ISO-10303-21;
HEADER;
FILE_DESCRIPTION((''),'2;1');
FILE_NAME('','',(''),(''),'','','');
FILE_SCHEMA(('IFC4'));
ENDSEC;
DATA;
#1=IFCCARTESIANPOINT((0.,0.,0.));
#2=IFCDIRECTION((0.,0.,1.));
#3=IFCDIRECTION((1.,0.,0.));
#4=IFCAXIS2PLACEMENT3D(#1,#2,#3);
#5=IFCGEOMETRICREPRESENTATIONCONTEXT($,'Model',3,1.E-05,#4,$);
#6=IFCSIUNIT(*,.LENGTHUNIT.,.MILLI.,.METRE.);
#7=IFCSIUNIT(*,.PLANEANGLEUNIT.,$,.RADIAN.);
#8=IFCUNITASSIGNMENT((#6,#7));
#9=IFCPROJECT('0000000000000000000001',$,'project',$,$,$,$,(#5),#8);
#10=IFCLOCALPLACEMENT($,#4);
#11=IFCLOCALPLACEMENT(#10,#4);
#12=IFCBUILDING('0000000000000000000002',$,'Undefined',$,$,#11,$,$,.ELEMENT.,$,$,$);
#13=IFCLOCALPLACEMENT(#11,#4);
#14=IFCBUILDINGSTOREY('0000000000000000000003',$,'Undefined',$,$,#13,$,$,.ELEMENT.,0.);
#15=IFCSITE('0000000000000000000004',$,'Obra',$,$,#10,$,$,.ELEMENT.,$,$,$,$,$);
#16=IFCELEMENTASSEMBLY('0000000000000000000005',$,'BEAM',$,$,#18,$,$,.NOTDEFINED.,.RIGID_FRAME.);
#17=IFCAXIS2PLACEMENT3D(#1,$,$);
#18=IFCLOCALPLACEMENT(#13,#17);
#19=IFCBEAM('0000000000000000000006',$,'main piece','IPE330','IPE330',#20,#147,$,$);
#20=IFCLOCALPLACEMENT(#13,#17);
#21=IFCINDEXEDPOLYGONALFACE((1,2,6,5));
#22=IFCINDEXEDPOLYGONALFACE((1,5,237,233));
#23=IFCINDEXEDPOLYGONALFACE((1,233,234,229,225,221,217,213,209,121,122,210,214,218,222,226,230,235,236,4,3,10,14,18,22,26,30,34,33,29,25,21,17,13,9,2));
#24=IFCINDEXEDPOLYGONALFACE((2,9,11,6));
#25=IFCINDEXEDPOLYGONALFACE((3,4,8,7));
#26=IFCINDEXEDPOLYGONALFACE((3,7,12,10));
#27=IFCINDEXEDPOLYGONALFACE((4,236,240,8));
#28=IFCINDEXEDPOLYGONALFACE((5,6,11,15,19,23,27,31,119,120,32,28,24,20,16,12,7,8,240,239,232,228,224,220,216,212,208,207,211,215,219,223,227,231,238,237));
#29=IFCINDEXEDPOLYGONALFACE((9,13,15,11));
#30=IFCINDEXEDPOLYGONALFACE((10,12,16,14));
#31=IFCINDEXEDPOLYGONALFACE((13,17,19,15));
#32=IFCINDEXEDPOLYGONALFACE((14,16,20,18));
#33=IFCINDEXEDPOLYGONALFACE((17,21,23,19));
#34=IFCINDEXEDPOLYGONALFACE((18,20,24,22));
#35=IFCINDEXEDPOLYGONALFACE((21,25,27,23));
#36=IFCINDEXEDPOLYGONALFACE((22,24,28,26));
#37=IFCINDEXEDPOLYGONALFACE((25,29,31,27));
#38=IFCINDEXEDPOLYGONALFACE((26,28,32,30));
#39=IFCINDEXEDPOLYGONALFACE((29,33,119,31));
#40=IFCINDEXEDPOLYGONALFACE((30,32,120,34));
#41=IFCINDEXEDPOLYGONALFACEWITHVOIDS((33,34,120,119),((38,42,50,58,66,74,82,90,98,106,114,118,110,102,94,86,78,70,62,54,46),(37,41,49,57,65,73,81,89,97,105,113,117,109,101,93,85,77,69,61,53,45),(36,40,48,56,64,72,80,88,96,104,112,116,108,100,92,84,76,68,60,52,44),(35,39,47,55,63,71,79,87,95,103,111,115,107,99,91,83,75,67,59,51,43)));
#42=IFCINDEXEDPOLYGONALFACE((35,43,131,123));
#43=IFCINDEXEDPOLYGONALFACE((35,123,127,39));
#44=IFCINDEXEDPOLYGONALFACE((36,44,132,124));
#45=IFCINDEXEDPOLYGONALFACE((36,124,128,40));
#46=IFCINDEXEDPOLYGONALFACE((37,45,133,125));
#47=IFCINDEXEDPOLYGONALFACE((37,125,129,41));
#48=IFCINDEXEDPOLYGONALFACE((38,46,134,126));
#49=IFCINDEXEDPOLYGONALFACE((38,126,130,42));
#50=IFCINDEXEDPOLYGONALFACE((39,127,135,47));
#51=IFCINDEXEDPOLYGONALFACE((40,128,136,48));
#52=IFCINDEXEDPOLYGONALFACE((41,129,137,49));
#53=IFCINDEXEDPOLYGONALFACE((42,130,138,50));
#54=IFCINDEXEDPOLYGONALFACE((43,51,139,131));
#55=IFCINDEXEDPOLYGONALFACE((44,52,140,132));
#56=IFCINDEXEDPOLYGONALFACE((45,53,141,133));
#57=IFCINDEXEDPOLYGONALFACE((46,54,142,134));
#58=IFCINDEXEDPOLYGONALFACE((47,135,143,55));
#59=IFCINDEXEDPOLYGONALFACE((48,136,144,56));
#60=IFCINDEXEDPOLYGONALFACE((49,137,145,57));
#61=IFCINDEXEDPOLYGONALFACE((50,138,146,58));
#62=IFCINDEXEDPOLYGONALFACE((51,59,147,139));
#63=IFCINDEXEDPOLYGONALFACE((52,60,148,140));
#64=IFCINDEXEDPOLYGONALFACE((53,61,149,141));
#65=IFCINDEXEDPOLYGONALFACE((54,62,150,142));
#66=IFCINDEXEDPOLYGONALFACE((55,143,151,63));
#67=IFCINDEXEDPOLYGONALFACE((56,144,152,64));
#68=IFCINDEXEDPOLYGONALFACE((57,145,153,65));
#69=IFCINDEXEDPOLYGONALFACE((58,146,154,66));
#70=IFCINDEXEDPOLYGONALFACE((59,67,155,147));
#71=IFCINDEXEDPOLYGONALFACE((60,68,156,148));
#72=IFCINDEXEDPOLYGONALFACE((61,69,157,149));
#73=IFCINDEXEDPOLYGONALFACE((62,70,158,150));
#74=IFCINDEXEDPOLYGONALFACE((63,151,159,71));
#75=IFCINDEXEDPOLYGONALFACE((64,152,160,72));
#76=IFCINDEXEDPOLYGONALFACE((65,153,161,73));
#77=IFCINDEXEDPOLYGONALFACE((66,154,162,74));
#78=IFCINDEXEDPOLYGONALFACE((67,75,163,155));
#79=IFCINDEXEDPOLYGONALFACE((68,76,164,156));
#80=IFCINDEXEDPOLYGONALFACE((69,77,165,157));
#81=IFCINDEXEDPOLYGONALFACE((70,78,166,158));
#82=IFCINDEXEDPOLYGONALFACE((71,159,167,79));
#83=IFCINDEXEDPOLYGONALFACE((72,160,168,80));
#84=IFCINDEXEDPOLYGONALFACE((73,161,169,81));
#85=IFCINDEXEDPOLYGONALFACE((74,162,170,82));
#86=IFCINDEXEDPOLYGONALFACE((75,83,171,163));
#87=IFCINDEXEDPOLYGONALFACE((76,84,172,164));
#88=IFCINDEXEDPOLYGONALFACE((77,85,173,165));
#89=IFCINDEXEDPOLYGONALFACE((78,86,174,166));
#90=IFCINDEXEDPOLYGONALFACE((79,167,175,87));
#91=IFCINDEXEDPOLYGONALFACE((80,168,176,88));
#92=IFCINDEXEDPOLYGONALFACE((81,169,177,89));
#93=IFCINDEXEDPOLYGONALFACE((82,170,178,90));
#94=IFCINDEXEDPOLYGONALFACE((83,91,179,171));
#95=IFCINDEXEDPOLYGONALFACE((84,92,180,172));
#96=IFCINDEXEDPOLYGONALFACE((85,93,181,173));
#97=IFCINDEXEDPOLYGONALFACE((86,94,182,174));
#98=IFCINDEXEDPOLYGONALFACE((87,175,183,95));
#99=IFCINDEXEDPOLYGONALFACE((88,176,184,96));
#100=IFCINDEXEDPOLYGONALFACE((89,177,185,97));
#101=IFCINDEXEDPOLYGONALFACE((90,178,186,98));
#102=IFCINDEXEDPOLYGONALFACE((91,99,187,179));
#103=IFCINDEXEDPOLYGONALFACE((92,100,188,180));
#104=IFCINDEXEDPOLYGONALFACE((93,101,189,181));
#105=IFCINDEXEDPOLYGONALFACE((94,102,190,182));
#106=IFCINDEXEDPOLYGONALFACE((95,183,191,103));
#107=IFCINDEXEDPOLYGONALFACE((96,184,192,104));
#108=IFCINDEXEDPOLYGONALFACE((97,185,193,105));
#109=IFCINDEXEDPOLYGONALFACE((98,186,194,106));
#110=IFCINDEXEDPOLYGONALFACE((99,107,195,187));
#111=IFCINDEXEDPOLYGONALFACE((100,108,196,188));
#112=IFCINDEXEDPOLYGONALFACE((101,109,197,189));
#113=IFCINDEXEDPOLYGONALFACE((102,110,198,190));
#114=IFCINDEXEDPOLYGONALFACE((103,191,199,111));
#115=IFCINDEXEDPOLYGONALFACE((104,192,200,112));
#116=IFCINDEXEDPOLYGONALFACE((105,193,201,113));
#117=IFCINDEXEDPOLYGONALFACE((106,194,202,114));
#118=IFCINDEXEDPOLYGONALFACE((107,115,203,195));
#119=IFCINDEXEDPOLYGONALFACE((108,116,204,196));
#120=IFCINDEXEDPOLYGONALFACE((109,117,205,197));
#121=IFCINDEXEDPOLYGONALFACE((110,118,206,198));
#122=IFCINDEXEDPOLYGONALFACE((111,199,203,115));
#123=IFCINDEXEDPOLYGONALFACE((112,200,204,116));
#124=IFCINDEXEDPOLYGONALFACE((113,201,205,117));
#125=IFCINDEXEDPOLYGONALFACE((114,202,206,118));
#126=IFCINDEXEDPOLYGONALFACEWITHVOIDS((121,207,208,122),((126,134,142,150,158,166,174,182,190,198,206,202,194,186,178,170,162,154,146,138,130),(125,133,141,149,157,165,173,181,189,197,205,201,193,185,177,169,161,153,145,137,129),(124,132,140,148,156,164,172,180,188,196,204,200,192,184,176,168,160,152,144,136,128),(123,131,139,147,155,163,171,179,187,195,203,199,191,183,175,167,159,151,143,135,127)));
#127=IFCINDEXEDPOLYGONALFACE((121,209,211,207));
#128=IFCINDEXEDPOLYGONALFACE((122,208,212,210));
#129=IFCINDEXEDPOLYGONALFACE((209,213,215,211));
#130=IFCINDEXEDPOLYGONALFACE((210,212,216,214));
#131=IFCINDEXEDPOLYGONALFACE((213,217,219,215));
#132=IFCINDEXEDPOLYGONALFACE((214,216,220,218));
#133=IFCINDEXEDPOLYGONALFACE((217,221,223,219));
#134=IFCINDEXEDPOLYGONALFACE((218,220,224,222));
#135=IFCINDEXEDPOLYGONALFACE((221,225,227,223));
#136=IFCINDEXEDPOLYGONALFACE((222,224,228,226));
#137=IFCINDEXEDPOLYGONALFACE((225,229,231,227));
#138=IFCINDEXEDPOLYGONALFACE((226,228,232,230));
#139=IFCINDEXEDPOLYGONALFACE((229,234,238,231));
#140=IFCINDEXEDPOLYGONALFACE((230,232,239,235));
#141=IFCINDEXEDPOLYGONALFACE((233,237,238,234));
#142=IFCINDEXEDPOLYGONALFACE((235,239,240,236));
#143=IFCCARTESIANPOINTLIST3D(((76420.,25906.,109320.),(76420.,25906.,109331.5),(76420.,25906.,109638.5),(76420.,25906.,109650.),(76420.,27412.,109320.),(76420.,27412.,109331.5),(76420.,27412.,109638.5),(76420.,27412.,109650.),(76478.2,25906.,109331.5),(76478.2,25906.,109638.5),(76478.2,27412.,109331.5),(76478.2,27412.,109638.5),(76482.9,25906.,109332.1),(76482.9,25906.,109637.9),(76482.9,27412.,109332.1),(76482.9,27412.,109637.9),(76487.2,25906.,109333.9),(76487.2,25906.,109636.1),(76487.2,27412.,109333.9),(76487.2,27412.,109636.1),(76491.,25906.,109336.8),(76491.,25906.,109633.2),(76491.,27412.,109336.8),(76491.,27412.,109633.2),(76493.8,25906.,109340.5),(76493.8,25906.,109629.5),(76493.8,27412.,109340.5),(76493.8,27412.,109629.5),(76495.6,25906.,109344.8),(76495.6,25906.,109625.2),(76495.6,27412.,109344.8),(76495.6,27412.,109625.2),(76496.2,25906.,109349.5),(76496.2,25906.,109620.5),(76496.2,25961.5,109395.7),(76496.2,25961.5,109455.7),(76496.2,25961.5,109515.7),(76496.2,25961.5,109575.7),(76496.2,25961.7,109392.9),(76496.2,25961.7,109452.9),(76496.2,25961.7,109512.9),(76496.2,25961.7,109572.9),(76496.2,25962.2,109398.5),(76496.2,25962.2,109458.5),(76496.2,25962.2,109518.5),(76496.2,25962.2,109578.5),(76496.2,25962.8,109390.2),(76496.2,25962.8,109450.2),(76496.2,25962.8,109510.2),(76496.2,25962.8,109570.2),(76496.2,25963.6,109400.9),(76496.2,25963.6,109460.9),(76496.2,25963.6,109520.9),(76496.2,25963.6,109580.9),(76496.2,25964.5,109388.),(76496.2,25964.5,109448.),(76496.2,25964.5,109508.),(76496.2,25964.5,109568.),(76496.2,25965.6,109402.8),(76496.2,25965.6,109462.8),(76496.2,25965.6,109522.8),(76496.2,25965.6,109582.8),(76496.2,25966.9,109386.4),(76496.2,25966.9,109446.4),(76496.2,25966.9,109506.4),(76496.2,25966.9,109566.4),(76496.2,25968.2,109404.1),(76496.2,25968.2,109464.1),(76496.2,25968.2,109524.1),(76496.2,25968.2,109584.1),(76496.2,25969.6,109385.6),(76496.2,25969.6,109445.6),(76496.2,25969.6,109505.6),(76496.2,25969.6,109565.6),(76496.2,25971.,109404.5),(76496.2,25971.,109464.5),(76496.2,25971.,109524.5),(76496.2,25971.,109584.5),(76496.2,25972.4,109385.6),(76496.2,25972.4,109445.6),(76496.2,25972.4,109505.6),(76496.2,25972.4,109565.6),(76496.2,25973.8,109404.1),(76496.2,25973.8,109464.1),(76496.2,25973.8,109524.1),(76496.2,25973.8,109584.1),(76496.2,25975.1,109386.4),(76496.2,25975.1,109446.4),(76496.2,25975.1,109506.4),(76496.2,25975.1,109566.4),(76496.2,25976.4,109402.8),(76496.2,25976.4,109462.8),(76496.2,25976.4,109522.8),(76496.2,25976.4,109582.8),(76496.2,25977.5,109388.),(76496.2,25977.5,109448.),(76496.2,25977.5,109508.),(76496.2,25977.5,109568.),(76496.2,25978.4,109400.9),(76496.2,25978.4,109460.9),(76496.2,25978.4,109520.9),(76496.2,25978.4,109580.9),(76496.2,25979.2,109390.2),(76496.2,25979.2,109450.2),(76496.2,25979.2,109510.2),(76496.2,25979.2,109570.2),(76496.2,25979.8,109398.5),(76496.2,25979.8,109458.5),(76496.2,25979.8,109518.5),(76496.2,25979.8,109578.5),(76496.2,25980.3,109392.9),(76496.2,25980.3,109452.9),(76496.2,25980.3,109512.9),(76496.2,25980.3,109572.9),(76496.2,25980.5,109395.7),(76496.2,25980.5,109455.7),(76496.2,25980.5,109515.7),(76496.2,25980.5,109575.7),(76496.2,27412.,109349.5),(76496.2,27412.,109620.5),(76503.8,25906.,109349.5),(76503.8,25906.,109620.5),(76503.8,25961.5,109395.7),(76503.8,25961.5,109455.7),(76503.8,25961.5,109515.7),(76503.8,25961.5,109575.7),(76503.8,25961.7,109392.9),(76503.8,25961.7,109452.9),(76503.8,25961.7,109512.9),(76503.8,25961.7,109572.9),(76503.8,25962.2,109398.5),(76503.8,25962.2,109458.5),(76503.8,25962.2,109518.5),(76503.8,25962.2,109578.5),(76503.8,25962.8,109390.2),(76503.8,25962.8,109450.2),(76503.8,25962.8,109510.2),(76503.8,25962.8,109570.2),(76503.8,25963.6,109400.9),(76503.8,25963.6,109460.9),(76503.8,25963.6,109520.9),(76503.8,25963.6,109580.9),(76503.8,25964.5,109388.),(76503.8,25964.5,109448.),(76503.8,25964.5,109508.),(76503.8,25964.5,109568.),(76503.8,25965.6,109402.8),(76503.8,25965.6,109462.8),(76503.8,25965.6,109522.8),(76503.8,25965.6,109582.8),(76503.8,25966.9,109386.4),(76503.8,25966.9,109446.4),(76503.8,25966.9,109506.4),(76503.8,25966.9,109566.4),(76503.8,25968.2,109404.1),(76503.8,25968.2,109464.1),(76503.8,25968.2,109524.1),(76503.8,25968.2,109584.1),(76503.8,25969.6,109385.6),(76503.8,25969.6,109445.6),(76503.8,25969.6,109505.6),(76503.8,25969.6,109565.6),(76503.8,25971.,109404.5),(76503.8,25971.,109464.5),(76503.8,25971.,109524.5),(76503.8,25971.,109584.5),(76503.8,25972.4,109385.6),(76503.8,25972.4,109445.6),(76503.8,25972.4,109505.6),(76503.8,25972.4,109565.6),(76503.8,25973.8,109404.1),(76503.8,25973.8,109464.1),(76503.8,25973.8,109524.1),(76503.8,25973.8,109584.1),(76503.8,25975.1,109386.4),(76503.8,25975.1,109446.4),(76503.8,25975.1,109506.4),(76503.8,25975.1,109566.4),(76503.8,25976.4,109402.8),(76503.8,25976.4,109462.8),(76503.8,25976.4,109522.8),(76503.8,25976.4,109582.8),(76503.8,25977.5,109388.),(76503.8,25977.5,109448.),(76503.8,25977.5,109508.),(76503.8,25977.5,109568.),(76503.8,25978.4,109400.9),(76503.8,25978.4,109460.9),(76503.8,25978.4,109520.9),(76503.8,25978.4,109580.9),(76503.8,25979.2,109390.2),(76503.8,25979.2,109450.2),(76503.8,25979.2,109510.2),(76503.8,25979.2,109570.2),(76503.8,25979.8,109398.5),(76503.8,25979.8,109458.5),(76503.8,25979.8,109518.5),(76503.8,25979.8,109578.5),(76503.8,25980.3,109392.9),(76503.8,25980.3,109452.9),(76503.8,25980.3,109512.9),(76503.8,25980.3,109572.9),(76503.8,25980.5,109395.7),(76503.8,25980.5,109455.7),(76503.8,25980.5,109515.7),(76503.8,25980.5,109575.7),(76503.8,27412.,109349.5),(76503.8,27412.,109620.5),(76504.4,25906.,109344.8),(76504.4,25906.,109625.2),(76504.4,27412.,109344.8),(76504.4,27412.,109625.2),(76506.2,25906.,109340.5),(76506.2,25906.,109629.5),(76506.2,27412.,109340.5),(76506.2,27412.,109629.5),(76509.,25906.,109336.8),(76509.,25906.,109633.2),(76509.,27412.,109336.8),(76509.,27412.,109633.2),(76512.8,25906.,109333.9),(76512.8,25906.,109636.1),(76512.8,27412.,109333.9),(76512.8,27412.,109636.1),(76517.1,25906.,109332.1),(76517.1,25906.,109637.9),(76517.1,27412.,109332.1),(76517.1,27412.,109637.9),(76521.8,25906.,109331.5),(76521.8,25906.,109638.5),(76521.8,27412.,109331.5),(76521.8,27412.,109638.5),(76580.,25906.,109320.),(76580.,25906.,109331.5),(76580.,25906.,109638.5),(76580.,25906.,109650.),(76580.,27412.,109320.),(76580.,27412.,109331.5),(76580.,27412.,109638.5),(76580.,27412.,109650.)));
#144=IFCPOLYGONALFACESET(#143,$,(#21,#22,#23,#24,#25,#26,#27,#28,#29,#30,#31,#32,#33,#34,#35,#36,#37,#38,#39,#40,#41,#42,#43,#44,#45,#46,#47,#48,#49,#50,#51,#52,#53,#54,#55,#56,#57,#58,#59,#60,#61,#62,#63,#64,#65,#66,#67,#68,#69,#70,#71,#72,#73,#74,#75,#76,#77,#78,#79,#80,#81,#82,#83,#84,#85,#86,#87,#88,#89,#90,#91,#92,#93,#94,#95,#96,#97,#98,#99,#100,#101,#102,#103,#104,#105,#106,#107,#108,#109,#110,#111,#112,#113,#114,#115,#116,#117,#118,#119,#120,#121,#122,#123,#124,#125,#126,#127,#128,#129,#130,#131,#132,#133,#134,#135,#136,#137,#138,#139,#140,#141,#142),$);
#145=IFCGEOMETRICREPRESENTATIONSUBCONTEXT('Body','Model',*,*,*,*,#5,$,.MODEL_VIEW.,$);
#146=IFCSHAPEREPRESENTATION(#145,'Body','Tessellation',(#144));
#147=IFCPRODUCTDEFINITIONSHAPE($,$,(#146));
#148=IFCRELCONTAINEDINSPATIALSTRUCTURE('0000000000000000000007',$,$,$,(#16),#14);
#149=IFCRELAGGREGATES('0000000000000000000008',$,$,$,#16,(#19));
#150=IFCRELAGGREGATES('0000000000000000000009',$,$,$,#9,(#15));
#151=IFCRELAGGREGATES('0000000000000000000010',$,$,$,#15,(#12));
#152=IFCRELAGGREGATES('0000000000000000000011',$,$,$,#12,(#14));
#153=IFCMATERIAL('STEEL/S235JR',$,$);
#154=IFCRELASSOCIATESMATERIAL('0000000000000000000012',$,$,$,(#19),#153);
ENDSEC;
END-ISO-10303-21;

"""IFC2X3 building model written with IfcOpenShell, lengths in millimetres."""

from ifc_helpers import new_model, si_unit, frame, origin_with_axes, origin_2d_with_axis, place, context, subcontext, project, spatial, circle, i_section, extrude, clip, halfspace, source, transform, mapped, material, element, aggregate, save


model = new_model("IFC2X3")

# Units and contexts
model_context = context("Model", 3, precision=1e-05, world=origin_with_axes())
body_context = subcontext(model_context, "Body", "Model", "MODEL_VIEW")
ifc_project = project(units=[si_unit("LENGTHUNIT", "METRE", prefix="MILLI"), si_unit("PLANEANGLEUNIT", "RADIAN")], contexts=[model_context])

# Site, building, storey
site_placement = place(None, origin_with_axes())
site = spatial("IfcSite", under=ifc_project, at=site_placement, Name="Obra", CompositionType="ELEMENT")
building_placement = place(site_placement, origin_with_axes())
building = spatial("IfcBuilding", under=site, at=building_placement, Name="Undefined", CompositionType="ELEMENT")
storey_placement = place(building_placement, origin_with_axes())
storey = spatial("IfcBuildingStorey", under=building, at=storey_placement, Name="Undefined", CompositionType="ELEMENT", Elevation=0.0)

# Shared definitions
ifc_material_1 = material(Name="STEEL/S235JR")

# Element assembly, beam, opening
assembly_1_placement = place(storey_placement, origin_with_axes())
assembly_1 = element("IfcElementAssembly", 1, at=assembly_1_placement, inside=storey, Name="BEAM", AssemblyPlace="NOTDEFINED", PredefinedType="RIGID_FRAME")
beam_1_placement = place(assembly_1_placement, frame((76500.0, 25898.7, 109485.0), z_axis=(0.0, 0.0, 1.0), x_axis=(0.0, 1.0, 0.0)))
beam_1 = element("IfcBeam", 2, at=beam_1_placement, material=ifc_material_1, Name="main piece", Description="IPE330", ObjectType="IPE330", context=body_context, shape_type="Clipping", body=[
    clip(extrude(i_section(OverallWidth=160.0, OverallDepth=330.0, WebThickness=7.5, FlangeThickness=11.5, FilletRadius=18.0, at=origin_2d_with_axis()), frame((1513.3, 0.0, 0.0), z_axis=(-1.0, 0.0, 0.0), x_axis=(0.0, -1.0, 0.0)), (0.0, 0.0, 1.0), 1506.0), halfspace(frame((7.3, 0.0, -220.0), z_axis=(1.0, 0.0, 0.0), x_axis=(0.0, -1.0, 0.0)), True)),
])
shared_shape_1 = source(origin_with_axes(), body_context, "Body", "SweptSolid", [
    extrude(circle(Radius=9.5, at=origin_2d_with_axis()), frame((0.0, -3.9, 0.0), z_axis=(0.0, 1.0, 0.0), x_axis=(1.0, 0.0, 0.0)), (0.0, 0.0, 1.0), 7.7),
])
opening_1_placement = place(assembly_1_placement, frame((76500.0, 25971.0, 109395.0), z_axis=(0.0, -1.0, 0.0), x_axis=(0.0, 0.0, 1.0)))
element("IfcOpeningElement", 3, at=opening_1_placement, cuts=beam_1, ObjectType="Opening", context=body_context, shape_type="MappedRepresentation", body=[
    mapped(shared_shape_1, transform((0.0, 0.0, 0.0))),
    mapped(shared_shape_1, transform((60.0, 0.0, 0.0))),
    mapped(shared_shape_1, transform((120.0, 0.0, 0.0))),
    mapped(shared_shape_1, transform((180.0, 0.0, 0.0))),
])
aggregate(assembly_1, [beam_1])

save(model, "model.ifc")
